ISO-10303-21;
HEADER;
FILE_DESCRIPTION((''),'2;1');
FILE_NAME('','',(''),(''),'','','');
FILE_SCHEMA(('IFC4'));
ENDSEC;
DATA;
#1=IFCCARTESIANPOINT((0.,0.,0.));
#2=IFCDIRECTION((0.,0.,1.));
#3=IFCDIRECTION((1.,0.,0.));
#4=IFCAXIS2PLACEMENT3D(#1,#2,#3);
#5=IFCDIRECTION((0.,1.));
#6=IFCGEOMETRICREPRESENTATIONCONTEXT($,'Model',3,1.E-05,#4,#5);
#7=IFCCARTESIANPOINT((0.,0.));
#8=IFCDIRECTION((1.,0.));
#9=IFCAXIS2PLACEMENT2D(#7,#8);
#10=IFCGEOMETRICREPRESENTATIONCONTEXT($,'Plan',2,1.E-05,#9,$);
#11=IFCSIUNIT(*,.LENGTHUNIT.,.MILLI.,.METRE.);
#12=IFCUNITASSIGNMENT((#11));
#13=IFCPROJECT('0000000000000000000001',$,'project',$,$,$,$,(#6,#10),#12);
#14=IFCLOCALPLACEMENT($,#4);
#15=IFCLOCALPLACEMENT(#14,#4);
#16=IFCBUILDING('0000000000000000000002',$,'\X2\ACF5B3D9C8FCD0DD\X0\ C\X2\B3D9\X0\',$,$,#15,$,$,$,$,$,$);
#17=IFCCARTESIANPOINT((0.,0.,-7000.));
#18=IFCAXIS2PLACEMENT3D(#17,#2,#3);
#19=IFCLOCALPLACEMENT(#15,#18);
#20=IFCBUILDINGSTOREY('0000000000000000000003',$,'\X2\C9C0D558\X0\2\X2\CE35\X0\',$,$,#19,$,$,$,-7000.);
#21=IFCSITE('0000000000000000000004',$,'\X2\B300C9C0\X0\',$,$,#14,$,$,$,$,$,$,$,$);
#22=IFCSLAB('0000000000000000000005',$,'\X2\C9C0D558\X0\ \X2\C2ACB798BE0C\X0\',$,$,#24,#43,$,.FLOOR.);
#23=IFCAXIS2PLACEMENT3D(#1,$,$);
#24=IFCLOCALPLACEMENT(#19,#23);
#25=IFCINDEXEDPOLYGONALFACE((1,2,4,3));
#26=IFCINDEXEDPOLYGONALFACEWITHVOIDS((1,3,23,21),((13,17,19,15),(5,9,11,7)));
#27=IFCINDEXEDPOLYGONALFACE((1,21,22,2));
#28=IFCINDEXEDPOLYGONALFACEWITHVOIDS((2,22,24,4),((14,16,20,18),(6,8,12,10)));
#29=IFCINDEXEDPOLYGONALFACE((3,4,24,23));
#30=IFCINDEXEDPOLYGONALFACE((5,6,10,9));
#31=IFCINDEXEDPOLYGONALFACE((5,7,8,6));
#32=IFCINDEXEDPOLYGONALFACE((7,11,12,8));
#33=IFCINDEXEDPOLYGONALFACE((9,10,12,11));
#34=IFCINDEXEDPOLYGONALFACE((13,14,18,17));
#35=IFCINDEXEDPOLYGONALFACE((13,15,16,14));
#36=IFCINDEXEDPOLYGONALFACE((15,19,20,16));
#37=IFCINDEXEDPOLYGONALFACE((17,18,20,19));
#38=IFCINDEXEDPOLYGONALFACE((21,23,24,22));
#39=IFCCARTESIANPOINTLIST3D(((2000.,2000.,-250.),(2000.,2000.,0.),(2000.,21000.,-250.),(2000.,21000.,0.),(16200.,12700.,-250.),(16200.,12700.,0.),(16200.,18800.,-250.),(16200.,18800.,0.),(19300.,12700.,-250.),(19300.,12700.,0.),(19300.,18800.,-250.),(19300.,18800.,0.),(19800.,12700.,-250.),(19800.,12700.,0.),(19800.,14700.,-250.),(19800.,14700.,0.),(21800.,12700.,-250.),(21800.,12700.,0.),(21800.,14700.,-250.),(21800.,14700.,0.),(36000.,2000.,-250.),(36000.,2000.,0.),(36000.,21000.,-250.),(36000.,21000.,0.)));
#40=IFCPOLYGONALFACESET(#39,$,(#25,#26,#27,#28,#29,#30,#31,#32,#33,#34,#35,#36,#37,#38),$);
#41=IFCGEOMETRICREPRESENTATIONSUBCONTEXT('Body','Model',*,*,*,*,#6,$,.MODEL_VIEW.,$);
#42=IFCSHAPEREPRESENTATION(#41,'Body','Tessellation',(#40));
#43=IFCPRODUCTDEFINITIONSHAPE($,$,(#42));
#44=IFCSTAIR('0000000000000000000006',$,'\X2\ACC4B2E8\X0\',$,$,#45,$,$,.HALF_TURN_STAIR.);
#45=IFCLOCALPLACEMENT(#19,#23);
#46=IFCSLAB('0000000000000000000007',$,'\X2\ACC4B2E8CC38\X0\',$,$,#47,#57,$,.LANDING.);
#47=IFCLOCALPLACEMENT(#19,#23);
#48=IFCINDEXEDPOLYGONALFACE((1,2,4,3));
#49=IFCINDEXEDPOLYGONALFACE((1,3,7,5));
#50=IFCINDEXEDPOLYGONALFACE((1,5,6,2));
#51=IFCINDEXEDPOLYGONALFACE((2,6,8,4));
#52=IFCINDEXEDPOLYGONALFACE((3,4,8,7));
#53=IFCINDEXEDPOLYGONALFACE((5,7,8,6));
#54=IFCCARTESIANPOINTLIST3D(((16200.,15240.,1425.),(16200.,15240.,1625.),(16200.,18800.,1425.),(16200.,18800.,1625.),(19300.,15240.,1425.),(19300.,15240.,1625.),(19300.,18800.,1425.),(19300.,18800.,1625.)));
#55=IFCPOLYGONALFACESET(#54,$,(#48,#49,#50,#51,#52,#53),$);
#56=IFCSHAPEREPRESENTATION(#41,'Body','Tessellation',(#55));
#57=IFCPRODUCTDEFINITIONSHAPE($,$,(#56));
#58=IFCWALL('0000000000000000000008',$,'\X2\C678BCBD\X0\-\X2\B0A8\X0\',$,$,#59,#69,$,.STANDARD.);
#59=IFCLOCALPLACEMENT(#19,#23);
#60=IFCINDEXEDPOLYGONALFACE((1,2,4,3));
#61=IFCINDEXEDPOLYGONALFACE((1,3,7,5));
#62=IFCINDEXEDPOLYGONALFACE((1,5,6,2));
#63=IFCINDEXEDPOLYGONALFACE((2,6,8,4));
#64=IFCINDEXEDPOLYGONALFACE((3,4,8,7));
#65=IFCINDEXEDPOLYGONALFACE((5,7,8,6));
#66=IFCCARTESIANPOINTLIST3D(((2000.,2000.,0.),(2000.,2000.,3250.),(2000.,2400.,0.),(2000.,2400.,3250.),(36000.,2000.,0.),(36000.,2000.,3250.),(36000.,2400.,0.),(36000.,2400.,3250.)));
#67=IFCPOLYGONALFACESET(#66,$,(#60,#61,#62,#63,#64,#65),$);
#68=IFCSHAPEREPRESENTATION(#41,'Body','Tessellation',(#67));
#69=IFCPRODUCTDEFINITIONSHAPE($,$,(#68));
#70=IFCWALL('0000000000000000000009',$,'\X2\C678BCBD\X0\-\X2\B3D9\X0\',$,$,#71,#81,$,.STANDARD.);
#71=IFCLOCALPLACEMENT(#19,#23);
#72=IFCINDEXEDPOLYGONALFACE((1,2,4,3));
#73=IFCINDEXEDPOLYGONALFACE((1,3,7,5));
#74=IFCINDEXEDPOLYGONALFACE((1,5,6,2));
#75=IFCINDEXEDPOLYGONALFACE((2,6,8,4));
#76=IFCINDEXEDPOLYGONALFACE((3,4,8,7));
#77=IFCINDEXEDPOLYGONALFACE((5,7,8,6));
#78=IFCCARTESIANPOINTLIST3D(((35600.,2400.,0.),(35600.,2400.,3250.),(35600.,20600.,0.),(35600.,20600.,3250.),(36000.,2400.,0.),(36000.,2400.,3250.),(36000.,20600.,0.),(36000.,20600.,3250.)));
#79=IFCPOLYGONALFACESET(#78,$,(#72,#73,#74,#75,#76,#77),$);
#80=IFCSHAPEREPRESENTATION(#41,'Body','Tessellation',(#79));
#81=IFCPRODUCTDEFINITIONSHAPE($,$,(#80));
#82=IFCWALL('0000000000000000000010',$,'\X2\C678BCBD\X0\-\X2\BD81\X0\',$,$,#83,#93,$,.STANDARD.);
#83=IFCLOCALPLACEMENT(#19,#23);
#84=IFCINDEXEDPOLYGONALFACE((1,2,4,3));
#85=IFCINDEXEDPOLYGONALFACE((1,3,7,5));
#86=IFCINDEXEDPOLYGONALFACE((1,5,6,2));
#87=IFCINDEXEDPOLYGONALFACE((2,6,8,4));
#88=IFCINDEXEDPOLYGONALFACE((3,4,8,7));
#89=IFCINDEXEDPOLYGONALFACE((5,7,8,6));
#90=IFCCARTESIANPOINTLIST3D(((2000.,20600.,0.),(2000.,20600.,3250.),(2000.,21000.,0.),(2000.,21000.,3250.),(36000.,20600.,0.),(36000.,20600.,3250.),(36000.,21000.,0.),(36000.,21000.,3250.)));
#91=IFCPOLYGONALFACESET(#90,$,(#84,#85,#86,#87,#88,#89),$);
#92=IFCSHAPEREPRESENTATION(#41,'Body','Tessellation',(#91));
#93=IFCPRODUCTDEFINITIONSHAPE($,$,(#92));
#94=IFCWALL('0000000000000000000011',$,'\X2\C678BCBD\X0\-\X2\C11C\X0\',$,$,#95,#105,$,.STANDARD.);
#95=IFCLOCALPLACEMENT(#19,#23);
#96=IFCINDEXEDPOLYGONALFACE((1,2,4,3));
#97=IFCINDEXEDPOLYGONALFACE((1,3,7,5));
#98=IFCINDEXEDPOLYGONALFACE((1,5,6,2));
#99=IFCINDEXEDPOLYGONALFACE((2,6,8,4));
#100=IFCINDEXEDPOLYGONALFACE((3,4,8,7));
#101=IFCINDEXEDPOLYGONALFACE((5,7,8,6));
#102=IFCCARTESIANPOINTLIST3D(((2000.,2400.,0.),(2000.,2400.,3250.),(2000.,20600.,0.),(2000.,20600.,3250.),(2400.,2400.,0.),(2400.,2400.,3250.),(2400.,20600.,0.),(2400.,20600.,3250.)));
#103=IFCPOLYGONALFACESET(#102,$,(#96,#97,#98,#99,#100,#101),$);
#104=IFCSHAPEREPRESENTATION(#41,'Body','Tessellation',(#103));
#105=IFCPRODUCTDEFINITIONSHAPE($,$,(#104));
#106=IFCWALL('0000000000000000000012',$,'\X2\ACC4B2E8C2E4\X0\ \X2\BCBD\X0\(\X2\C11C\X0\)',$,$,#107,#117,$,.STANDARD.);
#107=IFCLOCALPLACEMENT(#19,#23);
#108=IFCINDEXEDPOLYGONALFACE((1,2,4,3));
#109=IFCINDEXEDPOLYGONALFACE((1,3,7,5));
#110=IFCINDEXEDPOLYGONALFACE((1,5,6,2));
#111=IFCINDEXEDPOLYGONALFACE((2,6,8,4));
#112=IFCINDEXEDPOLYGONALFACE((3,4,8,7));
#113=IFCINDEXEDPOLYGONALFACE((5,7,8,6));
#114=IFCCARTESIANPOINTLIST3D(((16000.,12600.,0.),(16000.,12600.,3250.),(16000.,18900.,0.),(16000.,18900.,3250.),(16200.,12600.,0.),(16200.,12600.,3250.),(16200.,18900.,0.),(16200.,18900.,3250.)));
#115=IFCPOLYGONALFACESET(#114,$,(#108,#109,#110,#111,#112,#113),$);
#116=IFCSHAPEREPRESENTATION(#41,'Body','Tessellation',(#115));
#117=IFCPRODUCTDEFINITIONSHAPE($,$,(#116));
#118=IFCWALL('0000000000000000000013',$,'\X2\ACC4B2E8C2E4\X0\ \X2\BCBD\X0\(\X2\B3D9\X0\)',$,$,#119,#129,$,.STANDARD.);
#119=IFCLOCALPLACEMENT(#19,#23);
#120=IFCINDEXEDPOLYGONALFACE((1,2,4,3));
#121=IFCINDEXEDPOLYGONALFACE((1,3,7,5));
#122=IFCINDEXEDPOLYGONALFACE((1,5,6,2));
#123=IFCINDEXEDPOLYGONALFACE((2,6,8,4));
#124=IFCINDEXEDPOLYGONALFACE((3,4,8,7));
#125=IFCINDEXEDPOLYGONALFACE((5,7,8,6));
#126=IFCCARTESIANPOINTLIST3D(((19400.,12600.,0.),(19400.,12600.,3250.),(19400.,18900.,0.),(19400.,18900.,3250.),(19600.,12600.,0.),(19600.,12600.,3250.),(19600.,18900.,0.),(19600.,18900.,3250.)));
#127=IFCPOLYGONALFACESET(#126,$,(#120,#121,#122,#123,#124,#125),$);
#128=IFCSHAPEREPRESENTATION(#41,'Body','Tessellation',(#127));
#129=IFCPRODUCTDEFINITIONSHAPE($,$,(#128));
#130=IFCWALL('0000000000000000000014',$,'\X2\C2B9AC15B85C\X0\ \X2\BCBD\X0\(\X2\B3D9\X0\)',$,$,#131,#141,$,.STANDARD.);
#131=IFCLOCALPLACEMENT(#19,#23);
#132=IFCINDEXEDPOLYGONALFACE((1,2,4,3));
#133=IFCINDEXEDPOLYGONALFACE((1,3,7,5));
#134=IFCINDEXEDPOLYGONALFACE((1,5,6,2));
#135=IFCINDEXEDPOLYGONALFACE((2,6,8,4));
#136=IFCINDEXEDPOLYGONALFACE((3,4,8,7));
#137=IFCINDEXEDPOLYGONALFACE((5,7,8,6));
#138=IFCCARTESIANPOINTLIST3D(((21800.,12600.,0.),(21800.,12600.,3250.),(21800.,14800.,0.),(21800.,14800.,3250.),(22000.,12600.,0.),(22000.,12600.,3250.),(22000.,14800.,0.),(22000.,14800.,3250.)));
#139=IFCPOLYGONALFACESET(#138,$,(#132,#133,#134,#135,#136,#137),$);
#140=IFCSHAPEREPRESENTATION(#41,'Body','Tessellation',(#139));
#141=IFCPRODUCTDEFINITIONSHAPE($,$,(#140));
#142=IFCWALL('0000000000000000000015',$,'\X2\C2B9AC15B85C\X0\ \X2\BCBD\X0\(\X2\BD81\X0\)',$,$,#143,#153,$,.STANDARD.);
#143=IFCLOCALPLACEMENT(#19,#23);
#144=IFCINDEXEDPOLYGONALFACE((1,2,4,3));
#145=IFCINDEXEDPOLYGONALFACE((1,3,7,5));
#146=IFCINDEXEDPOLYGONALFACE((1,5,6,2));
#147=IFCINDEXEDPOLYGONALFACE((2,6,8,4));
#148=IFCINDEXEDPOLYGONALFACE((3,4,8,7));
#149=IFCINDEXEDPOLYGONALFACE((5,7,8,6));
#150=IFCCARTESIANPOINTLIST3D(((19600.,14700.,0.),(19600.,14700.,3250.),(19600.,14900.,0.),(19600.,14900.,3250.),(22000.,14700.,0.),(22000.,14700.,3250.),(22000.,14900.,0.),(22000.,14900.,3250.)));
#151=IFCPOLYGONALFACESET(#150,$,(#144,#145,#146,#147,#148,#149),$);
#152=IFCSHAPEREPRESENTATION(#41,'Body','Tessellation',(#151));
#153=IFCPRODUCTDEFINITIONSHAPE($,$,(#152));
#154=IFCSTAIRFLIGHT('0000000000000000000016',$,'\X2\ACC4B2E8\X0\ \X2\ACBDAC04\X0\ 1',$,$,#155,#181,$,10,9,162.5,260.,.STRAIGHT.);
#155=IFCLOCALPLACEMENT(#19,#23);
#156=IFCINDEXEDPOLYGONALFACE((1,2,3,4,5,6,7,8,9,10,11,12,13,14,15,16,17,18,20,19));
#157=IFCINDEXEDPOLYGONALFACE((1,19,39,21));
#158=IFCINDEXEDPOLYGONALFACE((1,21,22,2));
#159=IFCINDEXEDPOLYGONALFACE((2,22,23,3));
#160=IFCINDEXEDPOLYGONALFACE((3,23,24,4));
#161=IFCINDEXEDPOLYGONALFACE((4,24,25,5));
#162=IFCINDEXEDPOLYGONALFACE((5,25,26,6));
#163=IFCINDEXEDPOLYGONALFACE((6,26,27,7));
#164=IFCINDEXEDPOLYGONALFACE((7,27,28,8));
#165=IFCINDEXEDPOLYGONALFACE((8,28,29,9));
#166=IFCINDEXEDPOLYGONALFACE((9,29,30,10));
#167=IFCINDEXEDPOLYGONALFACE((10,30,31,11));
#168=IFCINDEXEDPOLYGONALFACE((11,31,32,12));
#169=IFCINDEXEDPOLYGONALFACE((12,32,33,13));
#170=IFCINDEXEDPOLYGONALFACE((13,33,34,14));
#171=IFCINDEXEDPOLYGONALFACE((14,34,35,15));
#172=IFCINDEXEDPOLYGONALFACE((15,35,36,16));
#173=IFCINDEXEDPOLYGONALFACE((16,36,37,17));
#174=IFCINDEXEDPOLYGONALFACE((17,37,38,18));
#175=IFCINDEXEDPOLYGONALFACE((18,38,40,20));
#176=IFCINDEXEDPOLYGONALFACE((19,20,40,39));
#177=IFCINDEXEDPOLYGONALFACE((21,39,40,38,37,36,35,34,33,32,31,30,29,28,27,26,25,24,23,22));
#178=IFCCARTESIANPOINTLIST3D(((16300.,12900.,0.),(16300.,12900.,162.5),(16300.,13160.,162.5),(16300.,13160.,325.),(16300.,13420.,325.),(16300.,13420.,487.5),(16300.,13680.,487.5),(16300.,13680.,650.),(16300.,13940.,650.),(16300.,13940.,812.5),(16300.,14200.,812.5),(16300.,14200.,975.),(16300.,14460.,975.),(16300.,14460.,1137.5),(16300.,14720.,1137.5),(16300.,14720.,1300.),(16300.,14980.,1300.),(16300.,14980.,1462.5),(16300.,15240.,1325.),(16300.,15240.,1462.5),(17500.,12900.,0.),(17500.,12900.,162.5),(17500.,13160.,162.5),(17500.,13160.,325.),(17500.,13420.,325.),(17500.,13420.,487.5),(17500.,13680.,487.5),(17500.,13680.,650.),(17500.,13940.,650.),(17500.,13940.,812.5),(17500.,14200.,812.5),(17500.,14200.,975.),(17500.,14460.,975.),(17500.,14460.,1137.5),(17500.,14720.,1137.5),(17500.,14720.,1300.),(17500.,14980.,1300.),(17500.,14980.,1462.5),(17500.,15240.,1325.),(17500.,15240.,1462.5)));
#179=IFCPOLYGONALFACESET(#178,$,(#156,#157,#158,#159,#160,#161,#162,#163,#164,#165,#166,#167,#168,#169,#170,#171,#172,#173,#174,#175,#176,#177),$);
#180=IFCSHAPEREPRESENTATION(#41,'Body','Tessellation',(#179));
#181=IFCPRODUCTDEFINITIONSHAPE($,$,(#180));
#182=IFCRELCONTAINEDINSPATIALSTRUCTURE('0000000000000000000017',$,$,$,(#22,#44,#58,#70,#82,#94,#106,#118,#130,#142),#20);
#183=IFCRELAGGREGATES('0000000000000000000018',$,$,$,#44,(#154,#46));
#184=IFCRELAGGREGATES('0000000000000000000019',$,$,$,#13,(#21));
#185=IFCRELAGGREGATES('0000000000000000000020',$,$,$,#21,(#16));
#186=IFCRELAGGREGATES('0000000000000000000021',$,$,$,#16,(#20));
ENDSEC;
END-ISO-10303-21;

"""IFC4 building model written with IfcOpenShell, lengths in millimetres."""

from ifc_helpers import new_model, si_unit, direction, frame, origin_with_axes, origin_2d_with_axis, place, context, subcontext, project, spatial, polyline, outline, extrude, element, aggregate, save


model = new_model("IFC4")

# Units and contexts
model_context = context("Model", 3, precision=1e-05, world=origin_with_axes(), true_north=direction((0.0, 1.0)))
plan_context = context("Plan", 2, precision=1e-05, world=origin_2d_with_axis())
body_context = subcontext(model_context, "Body", "Model", "MODEL_VIEW")
ifc_project = project(units=[si_unit("LENGTHUNIT", "METRE", prefix="MILLI")], contexts=[model_context, plan_context])

# Site, building, storey
site_placement = place(None, origin_with_axes())
site = spatial("IfcSite", under=ifc_project, at=site_placement, Name="대지")
building_placement = place(site_placement, origin_with_axes())
building = spatial("IfcBuilding", under=site, at=building_placement, Name="공동주택 C동")
storey_placement = place(building_placement, frame((0.0, 0.0, -7000.0), z_axis=(0.0, 0.0, 1.0), x_axis=(1.0, 0.0, 0.0)))
storey = spatial("IfcBuildingStorey", under=building, at=storey_placement, Name="지하2층", Elevation=-7000.0)

# Slab
slab_1_placement = place(storey_placement, origin_with_axes())
element("IfcSlab", 1, at=slab_1_placement, inside=storey, Name="지하 슬래브", PredefinedType="FLOOR", context=body_context, shape_type="SweptSolid", body=[
    extrude(outline(polyline([(2000.0, 2000.0), (36000.0, 2000.0), (36000.0, 21000.0), (2000.0, 21000.0), (2000.0, 2000.0)]), holes=[polyline([(16200.0, 12700.0), (19300.0, 12700.0), (19300.0, 18800.0), (16200.0, 18800.0), (16200.0, 12700.0)]), polyline([(19800.0, 12700.0), (21800.0, 12700.0), (21800.0, 14700.0), (19800.0, 14700.0), (19800.0, 12700.0)])]), frame((0.0, 0.0, -250.0), z_axis=(0.0, 0.0, 1.0), x_axis=(1.0, 0.0, 0.0)), (0.0, 0.0, 1.0), 250.0),
])

# Stair, slab
stair_placement = place(storey_placement, origin_with_axes())
stair = element("IfcStair", 2, at=stair_placement, inside=storey, Name="계단", PredefinedType="HALF_TURN_STAIR")
slab_2_placement = place(stair_placement, origin_with_axes())
slab_2 = element("IfcSlab", 3, at=slab_2_placement, Name="계단참", PredefinedType="LANDING", context=body_context, shape_type="SweptSolid", body=[
    extrude(outline(polyline([(16200.0, 15240.0), (19300.0, 15240.0), (19300.0, 18800.0), (16200.0, 18800.0), (16200.0, 15240.0)])), frame((0.0, 0.0, 1425.0), z_axis=(0.0, 0.0, 1.0), x_axis=(1.0, 0.0, 0.0)), (0.0, 0.0, 1.0), 200.0),
])

# Walls
wall_1_placement = place(storey_placement, origin_with_axes())
element("IfcWall", 4, at=wall_1_placement, inside=storey, Name="외벽-남", PredefinedType="STANDARD", context=body_context, shape_type="SweptSolid", body=[
    extrude(outline(polyline([(2000.0, 2400.0), (36000.0, 2400.0), (36000.0, 2000.0), (2000.0, 2000.0), (2000.0, 2400.0)])), origin_with_axes(), (0.0, 0.0, 1.0), 3250.0),
])
wall_2_placement = place(storey_placement, origin_with_axes())
element("IfcWall", 5, at=wall_2_placement, inside=storey, Name="외벽-동", PredefinedType="STANDARD", context=body_context, shape_type="SweptSolid", body=[
    extrude(outline(polyline([(35600.0, 2400.0), (35600.0, 20600.0), (36000.0, 20600.0), (36000.0, 2400.0), (35600.0, 2400.0)])), origin_with_axes(), (0.0, 0.0, 1.0), 3250.0),
])
wall_3_placement = place(storey_placement, origin_with_axes())
element("IfcWall", 6, at=wall_3_placement, inside=storey, Name="외벽-북", PredefinedType="STANDARD", context=body_context, shape_type="SweptSolid", body=[
    extrude(outline(polyline([(36000.0, 20600.0), (2000.0, 20600.0), (2000.0, 21000.0), (36000.0, 21000.0), (36000.0, 20600.0)])), origin_with_axes(), (0.0, 0.0, 1.0), 3250.0),
])
wall_4_placement = place(storey_placement, origin_with_axes())
element("IfcWall", 7, at=wall_4_placement, inside=storey, Name="외벽-서", PredefinedType="STANDARD", context=body_context, shape_type="SweptSolid", body=[
    extrude(outline(polyline([(2400.0, 20600.0), (2400.0, 2400.0), (2000.0, 2400.0), (2000.0, 20600.0), (2400.0, 20600.0)])), origin_with_axes(), (0.0, 0.0, 1.0), 3250.0),
])
wall_5_placement = place(storey_placement, origin_with_axes())
element("IfcWall", 8, at=wall_5_placement, inside=storey, Name="계단실 벽(서)", PredefinedType="STANDARD", context=body_context, shape_type="SweptSolid", body=[
    extrude(outline(polyline([(16000.0, 12600.0), (16000.0, 18900.0), (16200.0, 18900.0), (16200.0, 12600.0), (16000.0, 12600.0)])), origin_with_axes(), (0.0, 0.0, 1.0), 3250.0),
])
wall_6_placement = place(storey_placement, origin_with_axes())
element("IfcWall", 9, at=wall_6_placement, inside=storey, Name="계단실 벽(동)", PredefinedType="STANDARD", context=body_context, shape_type="SweptSolid", body=[
    extrude(outline(polyline([(19400.0, 12600.0), (19400.0, 18900.0), (19600.0, 18900.0), (19600.0, 12600.0), (19400.0, 12600.0)])), origin_with_axes(), (0.0, 0.0, 1.0), 3250.0),
])
wall_7_placement = place(storey_placement, origin_with_axes())
element("IfcWall", 10, at=wall_7_placement, inside=storey, Name="승강로 벽(동)", PredefinedType="STANDARD", context=body_context, shape_type="SweptSolid", body=[
    extrude(outline(polyline([(21800.0, 12600.0), (21800.0, 14800.0), (22000.0, 14800.0), (22000.0, 12600.0), (21800.0, 12600.0)])), origin_with_axes(), (0.0, 0.0, 1.0), 3250.0),
])
wall_8_placement = place(storey_placement, origin_with_axes())
element("IfcWall", 11, at=wall_8_placement, inside=storey, Name="승강로 벽(북)", PredefinedType="STANDARD", context=body_context, shape_type="SweptSolid", body=[
    extrude(outline(polyline([(19600.0, 14900.0), (22000.0, 14900.0), (22000.0, 14700.0), (19600.0, 14700.0), (19600.0, 14900.0)])), origin_with_axes(), (0.0, 0.0, 1.0), 3250.0),
])

# Stair flight
stair_flight_1_placement = place(stair_placement, origin_with_axes())
stair_flight_1 = element("IfcStairFlight", 12, at=stair_flight_1_placement, Name="계단 경간 1", NumberOfRisers=10, NumberOfTreads=9, PredefinedType="STRAIGHT", RiserHeight=162.5, TreadLength=260.0, context=body_context, shape_type="SweptSolid", body=[
    extrude(outline(polyline([(0.0, 0.0), (0.0, 162.5), (260.0, 162.5), (260.0, 325.0), (520.0, 325.0), (520.0, 487.5), (780.0, 487.5), (780.0, 650.0), (1040.0, 650.0), (1040.0, 812.5), (1300.0, 812.5), (1300.0, 975.0), (1560.0, 975.0), (1560.0, 1137.5), (1820.0, 1137.5), (1820.0, 1300.0), (2080.0, 1300.0), (2080.0, 1462.5), (2340.0, 1462.5), (2340.0, 1625.0), (2340.0, 1325.0), (0.0, 0.0)])), frame((16300.0, 12900.0, 0.0), z_axis=(1.0, 0.0, 0.0), x_axis=(0.0, 1.0, 0.0)), (0.0, 0.0, 1.0), 1200.0),
])

aggregate(stair, [stair_flight_1, slab_2])

save(model, "model.ifc")
